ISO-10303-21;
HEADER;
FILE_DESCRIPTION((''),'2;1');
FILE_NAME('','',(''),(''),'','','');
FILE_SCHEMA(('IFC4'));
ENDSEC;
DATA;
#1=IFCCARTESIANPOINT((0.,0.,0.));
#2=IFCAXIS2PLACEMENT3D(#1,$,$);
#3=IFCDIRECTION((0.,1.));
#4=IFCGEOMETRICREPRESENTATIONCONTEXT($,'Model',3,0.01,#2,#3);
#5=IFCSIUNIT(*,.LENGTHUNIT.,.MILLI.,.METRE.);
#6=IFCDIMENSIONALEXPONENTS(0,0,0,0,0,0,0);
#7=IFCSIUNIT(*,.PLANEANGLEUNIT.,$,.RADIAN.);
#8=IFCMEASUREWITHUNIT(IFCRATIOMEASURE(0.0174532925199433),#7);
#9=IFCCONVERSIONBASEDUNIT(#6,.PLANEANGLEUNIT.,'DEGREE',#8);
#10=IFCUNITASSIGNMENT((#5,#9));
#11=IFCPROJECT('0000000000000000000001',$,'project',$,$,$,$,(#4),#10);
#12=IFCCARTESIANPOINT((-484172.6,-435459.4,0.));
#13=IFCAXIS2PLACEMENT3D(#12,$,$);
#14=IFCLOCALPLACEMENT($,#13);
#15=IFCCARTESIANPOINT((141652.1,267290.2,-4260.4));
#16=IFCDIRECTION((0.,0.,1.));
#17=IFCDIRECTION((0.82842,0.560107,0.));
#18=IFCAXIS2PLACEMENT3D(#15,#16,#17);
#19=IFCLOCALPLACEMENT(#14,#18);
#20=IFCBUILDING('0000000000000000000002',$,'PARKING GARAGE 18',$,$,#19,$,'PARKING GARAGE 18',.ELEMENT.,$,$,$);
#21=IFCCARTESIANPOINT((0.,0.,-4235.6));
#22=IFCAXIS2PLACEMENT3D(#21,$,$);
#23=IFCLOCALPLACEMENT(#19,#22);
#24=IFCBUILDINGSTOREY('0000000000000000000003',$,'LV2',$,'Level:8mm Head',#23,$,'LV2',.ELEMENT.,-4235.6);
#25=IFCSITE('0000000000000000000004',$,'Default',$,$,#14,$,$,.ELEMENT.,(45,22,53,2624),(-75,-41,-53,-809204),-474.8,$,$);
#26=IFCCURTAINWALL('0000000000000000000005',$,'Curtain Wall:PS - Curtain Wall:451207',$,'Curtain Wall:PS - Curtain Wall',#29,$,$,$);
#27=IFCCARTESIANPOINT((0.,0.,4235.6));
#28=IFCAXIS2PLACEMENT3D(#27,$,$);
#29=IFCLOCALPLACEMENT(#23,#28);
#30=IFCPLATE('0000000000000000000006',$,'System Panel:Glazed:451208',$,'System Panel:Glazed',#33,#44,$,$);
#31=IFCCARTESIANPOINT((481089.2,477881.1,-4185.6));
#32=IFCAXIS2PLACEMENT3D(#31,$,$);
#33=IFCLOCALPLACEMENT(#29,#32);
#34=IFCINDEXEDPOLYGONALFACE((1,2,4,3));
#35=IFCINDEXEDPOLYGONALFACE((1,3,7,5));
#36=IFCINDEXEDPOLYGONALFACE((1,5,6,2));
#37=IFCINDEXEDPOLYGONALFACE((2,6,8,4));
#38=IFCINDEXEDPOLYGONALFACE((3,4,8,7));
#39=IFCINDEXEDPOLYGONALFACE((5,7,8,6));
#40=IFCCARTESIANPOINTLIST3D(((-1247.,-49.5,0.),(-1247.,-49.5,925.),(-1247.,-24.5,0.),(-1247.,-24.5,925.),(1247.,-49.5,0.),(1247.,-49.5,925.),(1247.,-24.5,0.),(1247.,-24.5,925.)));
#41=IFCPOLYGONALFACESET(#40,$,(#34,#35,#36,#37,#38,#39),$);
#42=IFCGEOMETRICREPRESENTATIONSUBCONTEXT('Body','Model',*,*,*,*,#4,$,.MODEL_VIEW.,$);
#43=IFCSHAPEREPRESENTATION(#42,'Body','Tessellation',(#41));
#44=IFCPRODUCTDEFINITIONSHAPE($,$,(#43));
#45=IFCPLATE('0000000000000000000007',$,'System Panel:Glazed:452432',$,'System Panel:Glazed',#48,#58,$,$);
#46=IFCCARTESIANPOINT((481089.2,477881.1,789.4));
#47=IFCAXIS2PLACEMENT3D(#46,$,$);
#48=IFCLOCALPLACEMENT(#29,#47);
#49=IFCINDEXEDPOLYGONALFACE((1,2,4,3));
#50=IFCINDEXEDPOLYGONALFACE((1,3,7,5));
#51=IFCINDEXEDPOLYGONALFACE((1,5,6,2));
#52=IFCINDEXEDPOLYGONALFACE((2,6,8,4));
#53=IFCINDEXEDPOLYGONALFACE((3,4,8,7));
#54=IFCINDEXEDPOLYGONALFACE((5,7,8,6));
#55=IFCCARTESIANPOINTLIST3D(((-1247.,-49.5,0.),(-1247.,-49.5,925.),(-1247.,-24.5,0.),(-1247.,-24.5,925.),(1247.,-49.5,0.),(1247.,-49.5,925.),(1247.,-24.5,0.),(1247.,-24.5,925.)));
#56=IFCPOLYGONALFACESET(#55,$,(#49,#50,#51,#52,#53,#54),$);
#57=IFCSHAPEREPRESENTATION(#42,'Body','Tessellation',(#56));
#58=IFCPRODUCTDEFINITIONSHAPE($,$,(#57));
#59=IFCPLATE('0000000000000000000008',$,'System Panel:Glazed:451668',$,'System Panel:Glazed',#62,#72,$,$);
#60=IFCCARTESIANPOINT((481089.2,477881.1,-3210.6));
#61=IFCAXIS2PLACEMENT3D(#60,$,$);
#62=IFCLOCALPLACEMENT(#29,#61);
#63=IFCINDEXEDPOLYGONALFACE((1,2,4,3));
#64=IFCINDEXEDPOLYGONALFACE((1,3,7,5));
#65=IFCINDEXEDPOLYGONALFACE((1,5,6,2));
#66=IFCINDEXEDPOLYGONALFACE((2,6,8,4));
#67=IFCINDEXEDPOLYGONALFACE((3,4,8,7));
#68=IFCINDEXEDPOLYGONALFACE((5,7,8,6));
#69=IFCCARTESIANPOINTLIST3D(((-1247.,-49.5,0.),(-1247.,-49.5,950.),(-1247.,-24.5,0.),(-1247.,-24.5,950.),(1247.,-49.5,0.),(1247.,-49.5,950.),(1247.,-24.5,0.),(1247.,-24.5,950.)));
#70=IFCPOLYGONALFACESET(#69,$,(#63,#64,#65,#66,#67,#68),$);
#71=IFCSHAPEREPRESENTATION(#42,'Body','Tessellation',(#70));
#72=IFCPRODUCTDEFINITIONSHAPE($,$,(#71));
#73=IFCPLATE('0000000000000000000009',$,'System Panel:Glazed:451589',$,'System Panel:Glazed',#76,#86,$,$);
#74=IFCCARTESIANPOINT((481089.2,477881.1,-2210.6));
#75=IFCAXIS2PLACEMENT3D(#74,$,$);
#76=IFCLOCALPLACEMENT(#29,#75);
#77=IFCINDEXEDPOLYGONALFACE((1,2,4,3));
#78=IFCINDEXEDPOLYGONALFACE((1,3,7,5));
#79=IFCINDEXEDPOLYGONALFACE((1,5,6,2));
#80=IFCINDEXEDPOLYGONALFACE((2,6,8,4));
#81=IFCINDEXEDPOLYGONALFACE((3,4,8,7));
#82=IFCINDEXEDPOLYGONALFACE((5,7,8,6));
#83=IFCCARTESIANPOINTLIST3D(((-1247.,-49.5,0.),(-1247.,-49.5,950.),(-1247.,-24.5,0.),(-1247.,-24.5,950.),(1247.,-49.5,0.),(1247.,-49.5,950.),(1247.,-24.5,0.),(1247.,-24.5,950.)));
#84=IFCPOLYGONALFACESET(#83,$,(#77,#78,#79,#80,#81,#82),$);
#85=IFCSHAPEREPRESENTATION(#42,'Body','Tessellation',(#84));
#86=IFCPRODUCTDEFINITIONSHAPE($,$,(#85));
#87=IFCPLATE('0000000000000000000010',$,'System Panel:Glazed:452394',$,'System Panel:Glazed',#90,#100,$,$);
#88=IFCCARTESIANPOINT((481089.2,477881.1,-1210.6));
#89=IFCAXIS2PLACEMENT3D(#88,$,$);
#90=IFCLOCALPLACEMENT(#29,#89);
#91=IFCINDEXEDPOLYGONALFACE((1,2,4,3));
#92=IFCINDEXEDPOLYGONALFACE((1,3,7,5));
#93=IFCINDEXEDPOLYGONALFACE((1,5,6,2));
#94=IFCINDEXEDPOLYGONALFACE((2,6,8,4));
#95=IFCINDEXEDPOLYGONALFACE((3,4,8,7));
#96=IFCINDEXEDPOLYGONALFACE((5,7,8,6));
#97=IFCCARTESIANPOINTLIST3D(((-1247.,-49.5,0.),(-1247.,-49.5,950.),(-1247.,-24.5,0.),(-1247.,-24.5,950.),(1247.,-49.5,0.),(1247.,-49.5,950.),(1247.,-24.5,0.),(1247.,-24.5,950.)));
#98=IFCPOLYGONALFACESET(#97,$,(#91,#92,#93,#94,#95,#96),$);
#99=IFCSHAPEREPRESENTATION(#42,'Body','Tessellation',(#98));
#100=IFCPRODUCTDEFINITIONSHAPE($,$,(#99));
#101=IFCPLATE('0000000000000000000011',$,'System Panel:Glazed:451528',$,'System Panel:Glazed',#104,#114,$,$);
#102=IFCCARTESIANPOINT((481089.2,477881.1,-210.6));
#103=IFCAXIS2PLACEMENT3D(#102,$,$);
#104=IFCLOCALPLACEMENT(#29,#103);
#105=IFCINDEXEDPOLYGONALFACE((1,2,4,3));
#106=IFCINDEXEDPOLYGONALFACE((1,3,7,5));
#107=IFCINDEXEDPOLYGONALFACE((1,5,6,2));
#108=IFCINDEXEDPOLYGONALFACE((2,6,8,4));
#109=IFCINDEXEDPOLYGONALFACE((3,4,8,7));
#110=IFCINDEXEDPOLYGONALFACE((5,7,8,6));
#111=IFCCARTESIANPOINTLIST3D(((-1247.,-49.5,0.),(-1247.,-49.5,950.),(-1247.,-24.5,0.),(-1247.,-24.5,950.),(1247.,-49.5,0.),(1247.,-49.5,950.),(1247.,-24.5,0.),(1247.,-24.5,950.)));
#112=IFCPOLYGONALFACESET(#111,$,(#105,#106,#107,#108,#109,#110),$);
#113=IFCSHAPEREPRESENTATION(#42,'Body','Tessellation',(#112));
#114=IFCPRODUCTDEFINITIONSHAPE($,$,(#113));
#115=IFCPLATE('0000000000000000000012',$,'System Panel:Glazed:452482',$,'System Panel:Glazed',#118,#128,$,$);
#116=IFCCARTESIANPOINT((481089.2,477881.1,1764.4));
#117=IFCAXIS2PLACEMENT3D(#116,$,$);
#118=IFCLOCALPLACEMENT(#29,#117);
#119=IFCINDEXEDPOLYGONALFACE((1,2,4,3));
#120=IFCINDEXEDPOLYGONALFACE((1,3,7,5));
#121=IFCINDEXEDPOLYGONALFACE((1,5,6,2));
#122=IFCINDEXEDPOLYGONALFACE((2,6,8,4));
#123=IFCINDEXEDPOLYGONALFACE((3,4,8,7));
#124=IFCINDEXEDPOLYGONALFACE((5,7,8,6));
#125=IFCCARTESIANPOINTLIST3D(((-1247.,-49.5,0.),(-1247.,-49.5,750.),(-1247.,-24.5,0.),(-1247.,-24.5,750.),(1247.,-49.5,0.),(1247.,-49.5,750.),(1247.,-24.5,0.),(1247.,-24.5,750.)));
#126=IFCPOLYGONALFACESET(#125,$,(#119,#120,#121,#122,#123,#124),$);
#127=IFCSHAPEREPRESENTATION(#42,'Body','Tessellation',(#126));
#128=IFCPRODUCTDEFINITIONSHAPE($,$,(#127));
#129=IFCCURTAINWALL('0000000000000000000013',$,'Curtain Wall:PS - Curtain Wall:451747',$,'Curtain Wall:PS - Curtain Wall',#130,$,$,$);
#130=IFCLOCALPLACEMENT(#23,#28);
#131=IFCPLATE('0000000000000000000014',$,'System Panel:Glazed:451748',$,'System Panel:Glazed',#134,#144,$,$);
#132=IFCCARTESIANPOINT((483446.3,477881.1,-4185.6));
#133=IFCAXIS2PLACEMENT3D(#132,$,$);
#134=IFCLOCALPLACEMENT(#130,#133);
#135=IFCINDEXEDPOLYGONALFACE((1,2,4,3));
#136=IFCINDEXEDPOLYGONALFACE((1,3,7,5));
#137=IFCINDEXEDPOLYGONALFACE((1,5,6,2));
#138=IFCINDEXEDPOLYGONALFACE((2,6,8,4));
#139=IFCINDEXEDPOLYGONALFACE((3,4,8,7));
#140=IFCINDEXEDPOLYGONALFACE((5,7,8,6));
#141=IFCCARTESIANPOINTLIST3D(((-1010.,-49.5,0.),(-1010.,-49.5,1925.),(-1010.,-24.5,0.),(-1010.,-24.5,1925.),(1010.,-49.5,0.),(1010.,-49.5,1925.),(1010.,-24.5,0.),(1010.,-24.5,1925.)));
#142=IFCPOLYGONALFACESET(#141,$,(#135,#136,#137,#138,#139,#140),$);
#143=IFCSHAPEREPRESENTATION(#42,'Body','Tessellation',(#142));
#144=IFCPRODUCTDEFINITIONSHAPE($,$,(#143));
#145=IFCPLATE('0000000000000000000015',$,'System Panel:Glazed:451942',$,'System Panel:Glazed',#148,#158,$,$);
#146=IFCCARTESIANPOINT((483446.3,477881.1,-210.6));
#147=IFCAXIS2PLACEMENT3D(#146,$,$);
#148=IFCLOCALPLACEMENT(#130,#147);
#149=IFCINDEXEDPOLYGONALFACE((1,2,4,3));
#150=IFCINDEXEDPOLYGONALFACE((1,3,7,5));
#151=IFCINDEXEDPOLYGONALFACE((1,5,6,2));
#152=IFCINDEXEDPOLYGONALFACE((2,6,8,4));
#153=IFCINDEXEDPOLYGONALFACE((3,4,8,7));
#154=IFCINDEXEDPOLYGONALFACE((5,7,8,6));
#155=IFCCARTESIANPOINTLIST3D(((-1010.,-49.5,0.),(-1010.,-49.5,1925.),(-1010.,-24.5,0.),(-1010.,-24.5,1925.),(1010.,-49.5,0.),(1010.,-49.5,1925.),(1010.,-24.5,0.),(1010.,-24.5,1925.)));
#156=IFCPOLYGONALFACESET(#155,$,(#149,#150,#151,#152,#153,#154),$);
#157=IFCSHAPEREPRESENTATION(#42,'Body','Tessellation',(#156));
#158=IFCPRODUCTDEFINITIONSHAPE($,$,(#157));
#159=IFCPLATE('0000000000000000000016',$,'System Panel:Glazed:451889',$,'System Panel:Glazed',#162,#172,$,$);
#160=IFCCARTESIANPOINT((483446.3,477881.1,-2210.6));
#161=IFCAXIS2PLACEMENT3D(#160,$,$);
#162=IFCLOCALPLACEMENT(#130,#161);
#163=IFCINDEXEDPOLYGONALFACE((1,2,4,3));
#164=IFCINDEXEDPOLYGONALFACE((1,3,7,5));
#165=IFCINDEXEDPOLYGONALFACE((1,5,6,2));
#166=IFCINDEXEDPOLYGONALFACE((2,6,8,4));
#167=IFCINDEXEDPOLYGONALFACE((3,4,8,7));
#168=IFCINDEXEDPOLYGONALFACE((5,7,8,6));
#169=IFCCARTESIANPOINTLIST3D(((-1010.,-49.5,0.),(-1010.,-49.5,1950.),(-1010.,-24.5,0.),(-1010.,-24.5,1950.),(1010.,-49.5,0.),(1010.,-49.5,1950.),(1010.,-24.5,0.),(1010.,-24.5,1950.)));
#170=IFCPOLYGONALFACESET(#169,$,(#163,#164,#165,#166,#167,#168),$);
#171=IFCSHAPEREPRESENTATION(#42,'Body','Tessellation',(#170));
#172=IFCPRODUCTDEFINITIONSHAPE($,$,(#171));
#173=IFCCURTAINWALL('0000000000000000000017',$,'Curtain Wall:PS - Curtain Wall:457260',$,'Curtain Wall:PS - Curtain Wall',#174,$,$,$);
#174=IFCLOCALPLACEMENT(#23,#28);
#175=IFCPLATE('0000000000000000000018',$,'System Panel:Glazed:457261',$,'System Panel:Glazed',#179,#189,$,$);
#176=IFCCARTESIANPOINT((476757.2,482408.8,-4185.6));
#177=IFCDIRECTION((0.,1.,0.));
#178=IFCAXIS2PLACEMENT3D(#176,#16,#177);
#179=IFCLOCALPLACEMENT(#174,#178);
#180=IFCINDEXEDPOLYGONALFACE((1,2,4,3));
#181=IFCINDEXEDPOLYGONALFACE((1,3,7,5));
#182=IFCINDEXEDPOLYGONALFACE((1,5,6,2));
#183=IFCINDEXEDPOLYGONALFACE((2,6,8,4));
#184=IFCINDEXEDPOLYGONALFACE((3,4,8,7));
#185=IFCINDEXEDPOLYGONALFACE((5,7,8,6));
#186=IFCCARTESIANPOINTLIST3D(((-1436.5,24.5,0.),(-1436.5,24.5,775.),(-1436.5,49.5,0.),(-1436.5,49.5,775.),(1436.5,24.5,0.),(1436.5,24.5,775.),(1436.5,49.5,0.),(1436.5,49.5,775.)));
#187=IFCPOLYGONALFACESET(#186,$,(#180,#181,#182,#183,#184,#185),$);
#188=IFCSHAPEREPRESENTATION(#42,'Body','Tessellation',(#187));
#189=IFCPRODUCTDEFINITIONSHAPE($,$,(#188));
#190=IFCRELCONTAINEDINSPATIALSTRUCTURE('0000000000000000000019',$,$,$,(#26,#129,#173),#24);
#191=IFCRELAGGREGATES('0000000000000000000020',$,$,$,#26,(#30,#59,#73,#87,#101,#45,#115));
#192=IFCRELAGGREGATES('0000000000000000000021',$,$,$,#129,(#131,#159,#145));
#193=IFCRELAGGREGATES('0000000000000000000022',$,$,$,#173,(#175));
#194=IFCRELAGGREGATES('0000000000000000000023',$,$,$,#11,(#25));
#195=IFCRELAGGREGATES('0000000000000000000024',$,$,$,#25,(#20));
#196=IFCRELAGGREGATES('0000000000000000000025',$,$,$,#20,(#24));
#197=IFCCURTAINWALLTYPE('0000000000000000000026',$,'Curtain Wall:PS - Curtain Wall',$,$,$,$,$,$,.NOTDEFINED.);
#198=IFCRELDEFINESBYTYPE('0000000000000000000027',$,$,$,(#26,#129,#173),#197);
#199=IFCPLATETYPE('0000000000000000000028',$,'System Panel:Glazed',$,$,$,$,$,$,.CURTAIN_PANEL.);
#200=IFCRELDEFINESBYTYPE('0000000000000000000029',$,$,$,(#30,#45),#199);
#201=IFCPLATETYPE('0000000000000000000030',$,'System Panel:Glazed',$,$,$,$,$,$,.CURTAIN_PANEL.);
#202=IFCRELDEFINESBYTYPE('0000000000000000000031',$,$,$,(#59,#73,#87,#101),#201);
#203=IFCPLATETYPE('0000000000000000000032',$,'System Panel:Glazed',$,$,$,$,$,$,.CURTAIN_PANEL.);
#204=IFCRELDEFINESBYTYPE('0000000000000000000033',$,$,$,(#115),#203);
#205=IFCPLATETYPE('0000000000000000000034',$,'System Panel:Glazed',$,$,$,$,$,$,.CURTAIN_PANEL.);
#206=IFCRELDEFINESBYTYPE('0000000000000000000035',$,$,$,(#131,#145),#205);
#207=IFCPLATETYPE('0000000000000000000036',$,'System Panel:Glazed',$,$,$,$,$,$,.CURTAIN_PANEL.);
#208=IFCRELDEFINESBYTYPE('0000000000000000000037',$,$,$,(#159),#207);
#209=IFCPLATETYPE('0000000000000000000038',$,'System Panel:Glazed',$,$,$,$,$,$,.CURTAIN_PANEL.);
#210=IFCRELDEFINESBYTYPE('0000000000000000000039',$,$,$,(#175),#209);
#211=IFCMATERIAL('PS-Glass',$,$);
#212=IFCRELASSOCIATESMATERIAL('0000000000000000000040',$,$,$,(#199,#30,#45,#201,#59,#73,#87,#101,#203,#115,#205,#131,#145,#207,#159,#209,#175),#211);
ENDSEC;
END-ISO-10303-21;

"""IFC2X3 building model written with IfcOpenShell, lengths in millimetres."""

from ifc_helpers import new_model, entity, si_unit, converted_unit, direction, frame, frame_2d, origin, origin_2d_with_axis, place, context, subcontext, project, spatial, rectangle, extrude, source, transform, mapped, material, type_object, type_shapes, element, aggregate, save


model = new_model("IFC2X3")

# Units and contexts
model_context = context("Model", 3, precision=0.01, world=origin(), true_north=direction((0.0, 1.0)))
body_context = subcontext(model_context, "Body", "Model", "MODEL_VIEW")
ifc_project = project(units=[si_unit("LENGTHUNIT", "METRE", prefix="MILLI"), converted_unit("PLANEANGLEUNIT", "DEGREE", entity("IfcRatioMeasure", 0.0174532925199433), si_unit("PLANEANGLEUNIT", "RADIAN"), dimensions=[0, 0, 0, 0, 0, 0, 0])], contexts=[model_context])

# Site, building, storey
site_placement = place(None, frame((-484172.6, -435459.4, 0.0)))
site = spatial("IfcSite", under=ifc_project, at=site_placement, Name="Default", CompositionType="ELEMENT", RefLatitude=(45, 22, 53, 2624), RefLongitude=(-75, -41, -53, -809204), RefElevation=-474.8)
building_placement = place(site_placement, frame((141652.1, 267290.2, -4260.4), z_axis=(0.0, 0.0, 1.0), x_axis=(0.82842, 0.560107, 0.0)))
building = spatial("IfcBuilding", under=site, at=building_placement, Name="PARKING GARAGE 18", LongName="PARKING GARAGE 18", CompositionType="ELEMENT")
storey_placement = place(building_placement, frame((0.0, 0.0, -4235.6)))
storey = spatial("IfcBuildingStorey", under=building, at=storey_placement, Name="LV2", ObjectType="Level:8mm Head", LongName="LV2", CompositionType="ELEMENT", Elevation=-4235.6)

# Curtain walls, plates
curtain_wall_type = type_object("IfcCurtainWallType", Name="Curtain Wall:PS - Curtain Wall", PredefinedType="NOTDEFINED")
curtain_wall_1_placement = place(storey_placement, frame((0.0, 0.0, 4235.6)))
curtain_wall_1 = element("IfcCurtainWall", 1, at=curtain_wall_1_placement, inside=storey, type_object=curtain_wall_type, Name="Curtain Wall:PS - Curtain Wall:451207", ObjectType="Curtain Wall:PS - Curtain Wall")
ifc_material_1 = material(Name="PS-Glass")
plate_type_1 = type_object("IfcPlateType", Name="System Panel:Glazed", PredefinedType="CURTAIN_PANEL", material=ifc_material_1)
shared_shape_1 = source(origin(), body_context, "Body", "SweptSolid", [
    extrude(rectangle(XDim=25.0, YDim=2494.1, at=frame_2d((0.0, 0.0), x_axis=(1.0, 0.0))), frame((0.0, -37.0, 0.0), z_axis=(0.0, 0.0, 1.0), x_axis=(0.0, 1.0, 0.0)), (0.0, 0.0, 1.0), 925.0),
])
type_shapes(plate_type_1, [shared_shape_1])
plate_1_placement = place(curtain_wall_1_placement, frame((481089.2, 477881.1, -4185.6)))
plate_1 = element("IfcPlate", 2, at=plate_1_placement, type_object=plate_type_1, material=ifc_material_1, Name="System Panel:Glazed:451208", ObjectType="System Panel:Glazed", context=body_context, shape_type="MappedRepresentation", body=[
    mapped(shared_shape_1, transform((0.0, 0.0, 0.0), scale=1.0)),
])
plate_2_placement = place(curtain_wall_1_placement, frame((481089.2, 477881.1, 789.4)))
plate_2 = element("IfcPlate", 3, at=plate_2_placement, type_object=plate_type_1, material=ifc_material_1, Name="System Panel:Glazed:452432", ObjectType="System Panel:Glazed", context=body_context, shape_type="MappedRepresentation", body=[
    mapped(shared_shape_1, transform((0.0, 0.0, 0.0), scale=1.0)),
])
plate_type_2 = type_object("IfcPlateType", Name="System Panel:Glazed", PredefinedType="CURTAIN_PANEL", material=ifc_material_1)
shared_shape_2 = source(origin(), body_context, "Body", "SweptSolid", [
    extrude(rectangle(XDim=25.0, YDim=2494.1, at=frame_2d((0.0, 0.0), x_axis=(1.0, 0.0))), frame((0.0, -37.0, 0.0), z_axis=(0.0, 0.0, 1.0), x_axis=(0.0, 1.0, 0.0)), (0.0, 0.0, 1.0), 950.0),
])
type_shapes(plate_type_2, [shared_shape_2])
plate_3_placement = place(curtain_wall_1_placement, frame((481089.2, 477881.1, -3210.6)))
plate_3 = element("IfcPlate", 4, at=plate_3_placement, type_object=plate_type_2, material=ifc_material_1, Name="System Panel:Glazed:451668", ObjectType="System Panel:Glazed", context=body_context, shape_type="MappedRepresentation", body=[
    mapped(shared_shape_2, transform((0.0, 0.0, 0.0), scale=1.0)),
])
plate_4_placement = place(curtain_wall_1_placement, frame((481089.2, 477881.1, -2210.6)))
plate_4 = element("IfcPlate", 5, at=plate_4_placement, type_object=plate_type_2, material=ifc_material_1, Name="System Panel:Glazed:451589", ObjectType="System Panel:Glazed", context=body_context, shape_type="MappedRepresentation", body=[
    mapped(shared_shape_2, transform((0.0, 0.0, 0.0), scale=1.0)),
])
plate_5_placement = place(curtain_wall_1_placement, frame((481089.2, 477881.1, -1210.6)))
plate_5 = element("IfcPlate", 6, at=plate_5_placement, type_object=plate_type_2, material=ifc_material_1, Name="System Panel:Glazed:452394", ObjectType="System Panel:Glazed", context=body_context, shape_type="MappedRepresentation", body=[
    mapped(shared_shape_2, transform((0.0, 0.0, 0.0), scale=1.0)),
])
plate_6_placement = place(curtain_wall_1_placement, frame((481089.2, 477881.1, -210.6)))
plate_6 = element("IfcPlate", 7, at=plate_6_placement, type_object=plate_type_2, material=ifc_material_1, Name="System Panel:Glazed:451528", ObjectType="System Panel:Glazed", context=body_context, shape_type="MappedRepresentation", body=[
    mapped(shared_shape_2, transform((0.0, 0.0, 0.0), scale=1.0)),
])
plate_type_3 = type_object("IfcPlateType", Name="System Panel:Glazed", PredefinedType="CURTAIN_PANEL", material=ifc_material_1)
shared_shape_3 = source(origin(), body_context, "Body", "SweptSolid", [
    extrude(rectangle(XDim=25.0, YDim=2494.1, at=frame_2d((0.0, 0.0), x_axis=(1.0, 0.0))), frame((0.0, -37.0, 0.0), z_axis=(0.0, 0.0, 1.0), x_axis=(0.0, 1.0, 0.0)), (0.0, 0.0, 1.0), 750.0),
])
type_shapes(plate_type_3, [shared_shape_3])
plate_7_placement = place(curtain_wall_1_placement, frame((481089.2, 477881.1, 1764.4)))
plate_7 = element("IfcPlate", 8, at=plate_7_placement, type_object=plate_type_3, material=ifc_material_1, Name="System Panel:Glazed:452482", ObjectType="System Panel:Glazed", context=body_context, shape_type="MappedRepresentation", body=[
    mapped(shared_shape_3, transform((0.0, 0.0, 0.0), scale=1.0)),
])
aggregate(curtain_wall_1, [plate_1, plate_3, plate_4, plate_5, plate_6, plate_2, plate_7])
curtain_wall_2_placement = place(storey_placement, frame((0.0, 0.0, 4235.6)))
curtain_wall_2 = element("IfcCurtainWall", 9, at=curtain_wall_2_placement, inside=storey, type_object=curtain_wall_type, Name="Curtain Wall:PS - Curtain Wall:451747", ObjectType="Curtain Wall:PS - Curtain Wall")
plate_type_4 = type_object("IfcPlateType", Name="System Panel:Glazed", PredefinedType="CURTAIN_PANEL", material=ifc_material_1)
shared_shape_4 = source(origin(), body_context, "Body", "SweptSolid", [
    extrude(rectangle(XDim=25.0, YDim=2020.0, at=frame_2d((0.0, 0.0), x_axis=(1.0, 0.0))), frame((0.0, -37.0, 0.0), z_axis=(0.0, 0.0, 1.0), x_axis=(0.0, 1.0, 0.0)), (0.0, 0.0, 1.0), 1925.0),
])
type_shapes(plate_type_4, [shared_shape_4])
plate_8_placement = place(curtain_wall_2_placement, frame((483446.3, 477881.1, -4185.6)))
plate_8 = element("IfcPlate", 10, at=plate_8_placement, type_object=plate_type_4, material=ifc_material_1, Name="System Panel:Glazed:451748", ObjectType="System Panel:Glazed", context=body_context, shape_type="MappedRepresentation", body=[
    mapped(shared_shape_4, transform((0.0, 0.0, 0.0), scale=1.0)),
])
plate_9_placement = place(curtain_wall_2_placement, frame((483446.3, 477881.1, -210.6)))
plate_9 = element("IfcPlate", 11, at=plate_9_placement, type_object=plate_type_4, material=ifc_material_1, Name="System Panel:Glazed:451942", ObjectType="System Panel:Glazed", context=body_context, shape_type="MappedRepresentation", body=[
    mapped(shared_shape_4, transform((0.0, 0.0, 0.0), scale=1.0)),
])
plate_type_5 = type_object("IfcPlateType", Name="System Panel:Glazed", PredefinedType="CURTAIN_PANEL", material=ifc_material_1)
shared_shape_5 = source(origin(), body_context, "Body", "SweptSolid", [
    extrude(rectangle(XDim=25.0, YDim=2020.0, at=frame_2d((0.0, 0.0), x_axis=(1.0, 0.0))), frame((0.0, -37.0, 0.0), z_axis=(0.0, 0.0, 1.0), x_axis=(0.0, 1.0, 0.0)), (0.0, 0.0, 1.0), 1950.0),
])
type_shapes(plate_type_5, [shared_shape_5])
plate_10_placement = place(curtain_wall_2_placement, frame((483446.3, 477881.1, -2210.6)))
plate_10 = element("IfcPlate", 12, at=plate_10_placement, type_object=plate_type_5, material=ifc_material_1, Name="System Panel:Glazed:451889", ObjectType="System Panel:Glazed", context=body_context, shape_type="MappedRepresentation", body=[
    mapped(shared_shape_5, transform((0.0, 0.0, 0.0), scale=1.0)),
])
aggregate(curtain_wall_2, [plate_8, plate_10, plate_9])
curtain_wall_3_placement = place(storey_placement, frame((0.0, 0.0, 4235.6)))
curtain_wall_3 = element("IfcCurtainWall", 13, at=curtain_wall_3_placement, inside=storey, type_object=curtain_wall_type, Name="Curtain Wall:PS - Curtain Wall:457260", ObjectType="Curtain Wall:PS - Curtain Wall")
plate_type_6 = type_object("IfcPlateType", Name="System Panel:Glazed", PredefinedType="CURTAIN_PANEL", material=ifc_material_1)
shared_shape_6 = source(origin(), body_context, "Body", "SweptSolid", [
    extrude(rectangle(XDim=25.0, YDim=2873.0, at=origin_2d_with_axis()), frame((0.0, 37.0, 0.0), z_axis=(0.0, 0.0, 1.0), x_axis=(0.0, 1.0, 0.0)), (0.0, 0.0, 1.0), 775.0),
])
type_shapes(plate_type_6, [shared_shape_6])
plate_11_placement = place(curtain_wall_3_placement, frame((476757.2, 482408.8, -4185.6), z_axis=(0.0, 0.0, 1.0), x_axis=(0.0, 1.0, 0.0)))
plate_11 = element("IfcPlate", 14, at=plate_11_placement, type_object=plate_type_6, material=ifc_material_1, Name="System Panel:Glazed:457261", ObjectType="System Panel:Glazed", context=body_context, shape_type="MappedRepresentation", body=[
    mapped(shared_shape_6, transform((0.0, 0.0, 0.0), scale=1.0)),
])
aggregate(curtain_wall_3, [plate_11])

save(model, "model.ifc")
